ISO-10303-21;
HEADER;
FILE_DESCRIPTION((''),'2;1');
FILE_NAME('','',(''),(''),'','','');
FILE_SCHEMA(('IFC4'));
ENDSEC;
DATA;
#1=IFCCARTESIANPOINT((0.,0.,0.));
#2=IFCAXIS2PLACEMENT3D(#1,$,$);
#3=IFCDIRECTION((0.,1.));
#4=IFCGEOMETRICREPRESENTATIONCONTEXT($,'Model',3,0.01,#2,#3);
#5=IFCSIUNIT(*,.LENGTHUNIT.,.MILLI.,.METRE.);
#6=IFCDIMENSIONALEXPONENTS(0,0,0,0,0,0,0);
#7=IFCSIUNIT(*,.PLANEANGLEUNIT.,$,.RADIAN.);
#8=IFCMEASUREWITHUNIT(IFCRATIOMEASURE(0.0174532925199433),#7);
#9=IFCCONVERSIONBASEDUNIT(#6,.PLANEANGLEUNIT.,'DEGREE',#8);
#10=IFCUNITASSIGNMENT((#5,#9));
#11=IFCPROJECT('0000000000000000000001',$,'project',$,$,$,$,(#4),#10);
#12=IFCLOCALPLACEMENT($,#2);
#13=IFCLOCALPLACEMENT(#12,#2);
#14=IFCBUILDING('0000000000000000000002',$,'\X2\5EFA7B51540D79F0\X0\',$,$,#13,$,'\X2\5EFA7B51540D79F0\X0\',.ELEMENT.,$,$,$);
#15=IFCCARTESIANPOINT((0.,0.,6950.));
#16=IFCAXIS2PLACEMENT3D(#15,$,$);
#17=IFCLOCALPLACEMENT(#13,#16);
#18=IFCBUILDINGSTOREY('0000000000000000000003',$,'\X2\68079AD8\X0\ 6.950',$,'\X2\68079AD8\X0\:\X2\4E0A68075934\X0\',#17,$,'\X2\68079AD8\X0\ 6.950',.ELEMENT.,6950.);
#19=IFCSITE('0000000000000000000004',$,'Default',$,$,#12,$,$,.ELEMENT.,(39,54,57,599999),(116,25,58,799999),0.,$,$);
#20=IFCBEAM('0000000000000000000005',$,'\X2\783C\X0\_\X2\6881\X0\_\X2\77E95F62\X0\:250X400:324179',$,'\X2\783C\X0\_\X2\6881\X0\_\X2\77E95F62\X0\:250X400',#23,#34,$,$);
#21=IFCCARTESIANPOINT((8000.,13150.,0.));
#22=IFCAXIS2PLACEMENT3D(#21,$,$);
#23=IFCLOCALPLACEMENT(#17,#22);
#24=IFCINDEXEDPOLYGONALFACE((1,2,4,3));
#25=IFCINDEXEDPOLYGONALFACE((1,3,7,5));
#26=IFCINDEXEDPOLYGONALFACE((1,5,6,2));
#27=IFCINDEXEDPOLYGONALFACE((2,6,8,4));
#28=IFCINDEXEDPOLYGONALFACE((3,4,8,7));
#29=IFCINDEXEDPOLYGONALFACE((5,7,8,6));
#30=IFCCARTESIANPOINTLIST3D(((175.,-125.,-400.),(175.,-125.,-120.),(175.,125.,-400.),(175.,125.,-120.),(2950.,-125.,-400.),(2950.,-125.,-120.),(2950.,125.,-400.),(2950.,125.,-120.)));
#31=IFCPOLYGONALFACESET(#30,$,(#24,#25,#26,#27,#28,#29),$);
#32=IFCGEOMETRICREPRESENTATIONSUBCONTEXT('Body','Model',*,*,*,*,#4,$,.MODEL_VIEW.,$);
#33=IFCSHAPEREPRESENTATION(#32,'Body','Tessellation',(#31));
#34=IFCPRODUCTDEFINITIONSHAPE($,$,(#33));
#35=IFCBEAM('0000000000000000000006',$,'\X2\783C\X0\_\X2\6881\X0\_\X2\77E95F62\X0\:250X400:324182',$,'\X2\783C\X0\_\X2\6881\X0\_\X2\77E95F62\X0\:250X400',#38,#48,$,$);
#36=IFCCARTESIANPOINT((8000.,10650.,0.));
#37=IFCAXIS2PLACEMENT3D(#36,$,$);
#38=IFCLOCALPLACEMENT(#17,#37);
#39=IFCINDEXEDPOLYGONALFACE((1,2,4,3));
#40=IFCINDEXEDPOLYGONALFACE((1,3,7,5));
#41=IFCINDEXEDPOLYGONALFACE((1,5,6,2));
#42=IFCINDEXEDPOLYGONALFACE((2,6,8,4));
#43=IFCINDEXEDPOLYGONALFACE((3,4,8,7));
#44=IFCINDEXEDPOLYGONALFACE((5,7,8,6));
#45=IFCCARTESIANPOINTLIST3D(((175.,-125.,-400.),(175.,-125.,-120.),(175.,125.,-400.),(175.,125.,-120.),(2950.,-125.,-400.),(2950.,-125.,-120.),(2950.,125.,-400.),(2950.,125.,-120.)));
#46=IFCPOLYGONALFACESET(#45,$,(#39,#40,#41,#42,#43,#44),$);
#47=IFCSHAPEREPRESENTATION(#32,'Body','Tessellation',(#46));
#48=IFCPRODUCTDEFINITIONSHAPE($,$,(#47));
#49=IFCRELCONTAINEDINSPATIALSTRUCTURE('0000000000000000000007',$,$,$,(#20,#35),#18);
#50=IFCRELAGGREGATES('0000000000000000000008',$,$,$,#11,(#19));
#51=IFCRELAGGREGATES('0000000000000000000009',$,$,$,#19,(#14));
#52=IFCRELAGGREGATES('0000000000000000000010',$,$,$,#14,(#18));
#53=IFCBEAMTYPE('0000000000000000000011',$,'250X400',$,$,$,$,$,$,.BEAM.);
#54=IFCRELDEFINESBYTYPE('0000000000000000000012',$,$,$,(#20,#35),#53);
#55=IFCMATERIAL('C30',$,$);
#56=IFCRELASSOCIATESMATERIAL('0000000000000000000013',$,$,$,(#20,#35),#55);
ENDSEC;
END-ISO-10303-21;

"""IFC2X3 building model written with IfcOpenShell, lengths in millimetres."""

from ifc_helpers import new_model, entity, si_unit, converted_unit, direction, frame, frame_2d, origin, place, context, subcontext, project, spatial, rectangle, extrude, material, type_object, element, save


model = new_model("IFC2X3")

# Units and contexts
model_context = context("Model", 3, precision=0.01, world=origin(), true_north=direction((0.0, 1.0)))
body_context = subcontext(model_context, "Body", "Model", "MODEL_VIEW")
ifc_project = project(units=[si_unit("LENGTHUNIT", "METRE", prefix="MILLI"), converted_unit("PLANEANGLEUNIT", "DEGREE", entity("IfcRatioMeasure", 0.0174532925199433), si_unit("PLANEANGLEUNIT", "RADIAN"), dimensions=[0, 0, 0, 0, 0, 0, 0])], contexts=[model_context])

# Site, building, storey
site_placement = place(None, origin())
site = spatial("IfcSite", under=ifc_project, at=site_placement, Name="Default", CompositionType="ELEMENT", RefLatitude=(39, 54, 57, 599999), RefLongitude=(116, 25, 58, 799999), RefElevation=0.0)
building_placement = place(site_placement, origin())
building = spatial("IfcBuilding", under=site, at=building_placement, Name="建筑名称", LongName="建筑名称", CompositionType="ELEMENT")
storey_placement = place(building_placement, frame((0.0, 0.0, 6950.0)))
storey = spatial("IfcBuildingStorey", under=building, at=storey_placement, Name="标高 6.950", ObjectType="标高:上标头", LongName="标高 6.950", CompositionType="ELEMENT", Elevation=6950.0)

# Shared definitions
ifc_material = material(Name="C30")

# Beams
beam_type_1 = type_object("IfcBeamType", Name="250X400", PredefinedType="BEAM")
for number, where, name in (
    (1, (8000.0, 13150.0, 0.0), "砼_梁_矩形:250X400:324179"),
    (2, (8000.0, 10650.0, 0.0), "砼_梁_矩形:250X400:324182"),
):
    element("IfcBeam", number, at=place(storey_placement, frame(where)), inside=storey, type_object=beam_type_1, material=ifc_material, Name=name, ObjectType="砼_梁_矩形:250X400", context=body_context, shape_type="SweptSolid", body=[
        extrude(rectangle(XDim=280.0, YDim=250.0, at=frame_2d((0.0, 0.0), x_axis=(1.0, 0.0))), frame((175.0, 0.0, -260.0), z_axis=(1.0, 0.0, 0.0), x_axis=(0.0, 0.0, -1.0)), (0.0, 0.0, 1.0), 2775.0),
    ])

save(model, "model.ifc")
